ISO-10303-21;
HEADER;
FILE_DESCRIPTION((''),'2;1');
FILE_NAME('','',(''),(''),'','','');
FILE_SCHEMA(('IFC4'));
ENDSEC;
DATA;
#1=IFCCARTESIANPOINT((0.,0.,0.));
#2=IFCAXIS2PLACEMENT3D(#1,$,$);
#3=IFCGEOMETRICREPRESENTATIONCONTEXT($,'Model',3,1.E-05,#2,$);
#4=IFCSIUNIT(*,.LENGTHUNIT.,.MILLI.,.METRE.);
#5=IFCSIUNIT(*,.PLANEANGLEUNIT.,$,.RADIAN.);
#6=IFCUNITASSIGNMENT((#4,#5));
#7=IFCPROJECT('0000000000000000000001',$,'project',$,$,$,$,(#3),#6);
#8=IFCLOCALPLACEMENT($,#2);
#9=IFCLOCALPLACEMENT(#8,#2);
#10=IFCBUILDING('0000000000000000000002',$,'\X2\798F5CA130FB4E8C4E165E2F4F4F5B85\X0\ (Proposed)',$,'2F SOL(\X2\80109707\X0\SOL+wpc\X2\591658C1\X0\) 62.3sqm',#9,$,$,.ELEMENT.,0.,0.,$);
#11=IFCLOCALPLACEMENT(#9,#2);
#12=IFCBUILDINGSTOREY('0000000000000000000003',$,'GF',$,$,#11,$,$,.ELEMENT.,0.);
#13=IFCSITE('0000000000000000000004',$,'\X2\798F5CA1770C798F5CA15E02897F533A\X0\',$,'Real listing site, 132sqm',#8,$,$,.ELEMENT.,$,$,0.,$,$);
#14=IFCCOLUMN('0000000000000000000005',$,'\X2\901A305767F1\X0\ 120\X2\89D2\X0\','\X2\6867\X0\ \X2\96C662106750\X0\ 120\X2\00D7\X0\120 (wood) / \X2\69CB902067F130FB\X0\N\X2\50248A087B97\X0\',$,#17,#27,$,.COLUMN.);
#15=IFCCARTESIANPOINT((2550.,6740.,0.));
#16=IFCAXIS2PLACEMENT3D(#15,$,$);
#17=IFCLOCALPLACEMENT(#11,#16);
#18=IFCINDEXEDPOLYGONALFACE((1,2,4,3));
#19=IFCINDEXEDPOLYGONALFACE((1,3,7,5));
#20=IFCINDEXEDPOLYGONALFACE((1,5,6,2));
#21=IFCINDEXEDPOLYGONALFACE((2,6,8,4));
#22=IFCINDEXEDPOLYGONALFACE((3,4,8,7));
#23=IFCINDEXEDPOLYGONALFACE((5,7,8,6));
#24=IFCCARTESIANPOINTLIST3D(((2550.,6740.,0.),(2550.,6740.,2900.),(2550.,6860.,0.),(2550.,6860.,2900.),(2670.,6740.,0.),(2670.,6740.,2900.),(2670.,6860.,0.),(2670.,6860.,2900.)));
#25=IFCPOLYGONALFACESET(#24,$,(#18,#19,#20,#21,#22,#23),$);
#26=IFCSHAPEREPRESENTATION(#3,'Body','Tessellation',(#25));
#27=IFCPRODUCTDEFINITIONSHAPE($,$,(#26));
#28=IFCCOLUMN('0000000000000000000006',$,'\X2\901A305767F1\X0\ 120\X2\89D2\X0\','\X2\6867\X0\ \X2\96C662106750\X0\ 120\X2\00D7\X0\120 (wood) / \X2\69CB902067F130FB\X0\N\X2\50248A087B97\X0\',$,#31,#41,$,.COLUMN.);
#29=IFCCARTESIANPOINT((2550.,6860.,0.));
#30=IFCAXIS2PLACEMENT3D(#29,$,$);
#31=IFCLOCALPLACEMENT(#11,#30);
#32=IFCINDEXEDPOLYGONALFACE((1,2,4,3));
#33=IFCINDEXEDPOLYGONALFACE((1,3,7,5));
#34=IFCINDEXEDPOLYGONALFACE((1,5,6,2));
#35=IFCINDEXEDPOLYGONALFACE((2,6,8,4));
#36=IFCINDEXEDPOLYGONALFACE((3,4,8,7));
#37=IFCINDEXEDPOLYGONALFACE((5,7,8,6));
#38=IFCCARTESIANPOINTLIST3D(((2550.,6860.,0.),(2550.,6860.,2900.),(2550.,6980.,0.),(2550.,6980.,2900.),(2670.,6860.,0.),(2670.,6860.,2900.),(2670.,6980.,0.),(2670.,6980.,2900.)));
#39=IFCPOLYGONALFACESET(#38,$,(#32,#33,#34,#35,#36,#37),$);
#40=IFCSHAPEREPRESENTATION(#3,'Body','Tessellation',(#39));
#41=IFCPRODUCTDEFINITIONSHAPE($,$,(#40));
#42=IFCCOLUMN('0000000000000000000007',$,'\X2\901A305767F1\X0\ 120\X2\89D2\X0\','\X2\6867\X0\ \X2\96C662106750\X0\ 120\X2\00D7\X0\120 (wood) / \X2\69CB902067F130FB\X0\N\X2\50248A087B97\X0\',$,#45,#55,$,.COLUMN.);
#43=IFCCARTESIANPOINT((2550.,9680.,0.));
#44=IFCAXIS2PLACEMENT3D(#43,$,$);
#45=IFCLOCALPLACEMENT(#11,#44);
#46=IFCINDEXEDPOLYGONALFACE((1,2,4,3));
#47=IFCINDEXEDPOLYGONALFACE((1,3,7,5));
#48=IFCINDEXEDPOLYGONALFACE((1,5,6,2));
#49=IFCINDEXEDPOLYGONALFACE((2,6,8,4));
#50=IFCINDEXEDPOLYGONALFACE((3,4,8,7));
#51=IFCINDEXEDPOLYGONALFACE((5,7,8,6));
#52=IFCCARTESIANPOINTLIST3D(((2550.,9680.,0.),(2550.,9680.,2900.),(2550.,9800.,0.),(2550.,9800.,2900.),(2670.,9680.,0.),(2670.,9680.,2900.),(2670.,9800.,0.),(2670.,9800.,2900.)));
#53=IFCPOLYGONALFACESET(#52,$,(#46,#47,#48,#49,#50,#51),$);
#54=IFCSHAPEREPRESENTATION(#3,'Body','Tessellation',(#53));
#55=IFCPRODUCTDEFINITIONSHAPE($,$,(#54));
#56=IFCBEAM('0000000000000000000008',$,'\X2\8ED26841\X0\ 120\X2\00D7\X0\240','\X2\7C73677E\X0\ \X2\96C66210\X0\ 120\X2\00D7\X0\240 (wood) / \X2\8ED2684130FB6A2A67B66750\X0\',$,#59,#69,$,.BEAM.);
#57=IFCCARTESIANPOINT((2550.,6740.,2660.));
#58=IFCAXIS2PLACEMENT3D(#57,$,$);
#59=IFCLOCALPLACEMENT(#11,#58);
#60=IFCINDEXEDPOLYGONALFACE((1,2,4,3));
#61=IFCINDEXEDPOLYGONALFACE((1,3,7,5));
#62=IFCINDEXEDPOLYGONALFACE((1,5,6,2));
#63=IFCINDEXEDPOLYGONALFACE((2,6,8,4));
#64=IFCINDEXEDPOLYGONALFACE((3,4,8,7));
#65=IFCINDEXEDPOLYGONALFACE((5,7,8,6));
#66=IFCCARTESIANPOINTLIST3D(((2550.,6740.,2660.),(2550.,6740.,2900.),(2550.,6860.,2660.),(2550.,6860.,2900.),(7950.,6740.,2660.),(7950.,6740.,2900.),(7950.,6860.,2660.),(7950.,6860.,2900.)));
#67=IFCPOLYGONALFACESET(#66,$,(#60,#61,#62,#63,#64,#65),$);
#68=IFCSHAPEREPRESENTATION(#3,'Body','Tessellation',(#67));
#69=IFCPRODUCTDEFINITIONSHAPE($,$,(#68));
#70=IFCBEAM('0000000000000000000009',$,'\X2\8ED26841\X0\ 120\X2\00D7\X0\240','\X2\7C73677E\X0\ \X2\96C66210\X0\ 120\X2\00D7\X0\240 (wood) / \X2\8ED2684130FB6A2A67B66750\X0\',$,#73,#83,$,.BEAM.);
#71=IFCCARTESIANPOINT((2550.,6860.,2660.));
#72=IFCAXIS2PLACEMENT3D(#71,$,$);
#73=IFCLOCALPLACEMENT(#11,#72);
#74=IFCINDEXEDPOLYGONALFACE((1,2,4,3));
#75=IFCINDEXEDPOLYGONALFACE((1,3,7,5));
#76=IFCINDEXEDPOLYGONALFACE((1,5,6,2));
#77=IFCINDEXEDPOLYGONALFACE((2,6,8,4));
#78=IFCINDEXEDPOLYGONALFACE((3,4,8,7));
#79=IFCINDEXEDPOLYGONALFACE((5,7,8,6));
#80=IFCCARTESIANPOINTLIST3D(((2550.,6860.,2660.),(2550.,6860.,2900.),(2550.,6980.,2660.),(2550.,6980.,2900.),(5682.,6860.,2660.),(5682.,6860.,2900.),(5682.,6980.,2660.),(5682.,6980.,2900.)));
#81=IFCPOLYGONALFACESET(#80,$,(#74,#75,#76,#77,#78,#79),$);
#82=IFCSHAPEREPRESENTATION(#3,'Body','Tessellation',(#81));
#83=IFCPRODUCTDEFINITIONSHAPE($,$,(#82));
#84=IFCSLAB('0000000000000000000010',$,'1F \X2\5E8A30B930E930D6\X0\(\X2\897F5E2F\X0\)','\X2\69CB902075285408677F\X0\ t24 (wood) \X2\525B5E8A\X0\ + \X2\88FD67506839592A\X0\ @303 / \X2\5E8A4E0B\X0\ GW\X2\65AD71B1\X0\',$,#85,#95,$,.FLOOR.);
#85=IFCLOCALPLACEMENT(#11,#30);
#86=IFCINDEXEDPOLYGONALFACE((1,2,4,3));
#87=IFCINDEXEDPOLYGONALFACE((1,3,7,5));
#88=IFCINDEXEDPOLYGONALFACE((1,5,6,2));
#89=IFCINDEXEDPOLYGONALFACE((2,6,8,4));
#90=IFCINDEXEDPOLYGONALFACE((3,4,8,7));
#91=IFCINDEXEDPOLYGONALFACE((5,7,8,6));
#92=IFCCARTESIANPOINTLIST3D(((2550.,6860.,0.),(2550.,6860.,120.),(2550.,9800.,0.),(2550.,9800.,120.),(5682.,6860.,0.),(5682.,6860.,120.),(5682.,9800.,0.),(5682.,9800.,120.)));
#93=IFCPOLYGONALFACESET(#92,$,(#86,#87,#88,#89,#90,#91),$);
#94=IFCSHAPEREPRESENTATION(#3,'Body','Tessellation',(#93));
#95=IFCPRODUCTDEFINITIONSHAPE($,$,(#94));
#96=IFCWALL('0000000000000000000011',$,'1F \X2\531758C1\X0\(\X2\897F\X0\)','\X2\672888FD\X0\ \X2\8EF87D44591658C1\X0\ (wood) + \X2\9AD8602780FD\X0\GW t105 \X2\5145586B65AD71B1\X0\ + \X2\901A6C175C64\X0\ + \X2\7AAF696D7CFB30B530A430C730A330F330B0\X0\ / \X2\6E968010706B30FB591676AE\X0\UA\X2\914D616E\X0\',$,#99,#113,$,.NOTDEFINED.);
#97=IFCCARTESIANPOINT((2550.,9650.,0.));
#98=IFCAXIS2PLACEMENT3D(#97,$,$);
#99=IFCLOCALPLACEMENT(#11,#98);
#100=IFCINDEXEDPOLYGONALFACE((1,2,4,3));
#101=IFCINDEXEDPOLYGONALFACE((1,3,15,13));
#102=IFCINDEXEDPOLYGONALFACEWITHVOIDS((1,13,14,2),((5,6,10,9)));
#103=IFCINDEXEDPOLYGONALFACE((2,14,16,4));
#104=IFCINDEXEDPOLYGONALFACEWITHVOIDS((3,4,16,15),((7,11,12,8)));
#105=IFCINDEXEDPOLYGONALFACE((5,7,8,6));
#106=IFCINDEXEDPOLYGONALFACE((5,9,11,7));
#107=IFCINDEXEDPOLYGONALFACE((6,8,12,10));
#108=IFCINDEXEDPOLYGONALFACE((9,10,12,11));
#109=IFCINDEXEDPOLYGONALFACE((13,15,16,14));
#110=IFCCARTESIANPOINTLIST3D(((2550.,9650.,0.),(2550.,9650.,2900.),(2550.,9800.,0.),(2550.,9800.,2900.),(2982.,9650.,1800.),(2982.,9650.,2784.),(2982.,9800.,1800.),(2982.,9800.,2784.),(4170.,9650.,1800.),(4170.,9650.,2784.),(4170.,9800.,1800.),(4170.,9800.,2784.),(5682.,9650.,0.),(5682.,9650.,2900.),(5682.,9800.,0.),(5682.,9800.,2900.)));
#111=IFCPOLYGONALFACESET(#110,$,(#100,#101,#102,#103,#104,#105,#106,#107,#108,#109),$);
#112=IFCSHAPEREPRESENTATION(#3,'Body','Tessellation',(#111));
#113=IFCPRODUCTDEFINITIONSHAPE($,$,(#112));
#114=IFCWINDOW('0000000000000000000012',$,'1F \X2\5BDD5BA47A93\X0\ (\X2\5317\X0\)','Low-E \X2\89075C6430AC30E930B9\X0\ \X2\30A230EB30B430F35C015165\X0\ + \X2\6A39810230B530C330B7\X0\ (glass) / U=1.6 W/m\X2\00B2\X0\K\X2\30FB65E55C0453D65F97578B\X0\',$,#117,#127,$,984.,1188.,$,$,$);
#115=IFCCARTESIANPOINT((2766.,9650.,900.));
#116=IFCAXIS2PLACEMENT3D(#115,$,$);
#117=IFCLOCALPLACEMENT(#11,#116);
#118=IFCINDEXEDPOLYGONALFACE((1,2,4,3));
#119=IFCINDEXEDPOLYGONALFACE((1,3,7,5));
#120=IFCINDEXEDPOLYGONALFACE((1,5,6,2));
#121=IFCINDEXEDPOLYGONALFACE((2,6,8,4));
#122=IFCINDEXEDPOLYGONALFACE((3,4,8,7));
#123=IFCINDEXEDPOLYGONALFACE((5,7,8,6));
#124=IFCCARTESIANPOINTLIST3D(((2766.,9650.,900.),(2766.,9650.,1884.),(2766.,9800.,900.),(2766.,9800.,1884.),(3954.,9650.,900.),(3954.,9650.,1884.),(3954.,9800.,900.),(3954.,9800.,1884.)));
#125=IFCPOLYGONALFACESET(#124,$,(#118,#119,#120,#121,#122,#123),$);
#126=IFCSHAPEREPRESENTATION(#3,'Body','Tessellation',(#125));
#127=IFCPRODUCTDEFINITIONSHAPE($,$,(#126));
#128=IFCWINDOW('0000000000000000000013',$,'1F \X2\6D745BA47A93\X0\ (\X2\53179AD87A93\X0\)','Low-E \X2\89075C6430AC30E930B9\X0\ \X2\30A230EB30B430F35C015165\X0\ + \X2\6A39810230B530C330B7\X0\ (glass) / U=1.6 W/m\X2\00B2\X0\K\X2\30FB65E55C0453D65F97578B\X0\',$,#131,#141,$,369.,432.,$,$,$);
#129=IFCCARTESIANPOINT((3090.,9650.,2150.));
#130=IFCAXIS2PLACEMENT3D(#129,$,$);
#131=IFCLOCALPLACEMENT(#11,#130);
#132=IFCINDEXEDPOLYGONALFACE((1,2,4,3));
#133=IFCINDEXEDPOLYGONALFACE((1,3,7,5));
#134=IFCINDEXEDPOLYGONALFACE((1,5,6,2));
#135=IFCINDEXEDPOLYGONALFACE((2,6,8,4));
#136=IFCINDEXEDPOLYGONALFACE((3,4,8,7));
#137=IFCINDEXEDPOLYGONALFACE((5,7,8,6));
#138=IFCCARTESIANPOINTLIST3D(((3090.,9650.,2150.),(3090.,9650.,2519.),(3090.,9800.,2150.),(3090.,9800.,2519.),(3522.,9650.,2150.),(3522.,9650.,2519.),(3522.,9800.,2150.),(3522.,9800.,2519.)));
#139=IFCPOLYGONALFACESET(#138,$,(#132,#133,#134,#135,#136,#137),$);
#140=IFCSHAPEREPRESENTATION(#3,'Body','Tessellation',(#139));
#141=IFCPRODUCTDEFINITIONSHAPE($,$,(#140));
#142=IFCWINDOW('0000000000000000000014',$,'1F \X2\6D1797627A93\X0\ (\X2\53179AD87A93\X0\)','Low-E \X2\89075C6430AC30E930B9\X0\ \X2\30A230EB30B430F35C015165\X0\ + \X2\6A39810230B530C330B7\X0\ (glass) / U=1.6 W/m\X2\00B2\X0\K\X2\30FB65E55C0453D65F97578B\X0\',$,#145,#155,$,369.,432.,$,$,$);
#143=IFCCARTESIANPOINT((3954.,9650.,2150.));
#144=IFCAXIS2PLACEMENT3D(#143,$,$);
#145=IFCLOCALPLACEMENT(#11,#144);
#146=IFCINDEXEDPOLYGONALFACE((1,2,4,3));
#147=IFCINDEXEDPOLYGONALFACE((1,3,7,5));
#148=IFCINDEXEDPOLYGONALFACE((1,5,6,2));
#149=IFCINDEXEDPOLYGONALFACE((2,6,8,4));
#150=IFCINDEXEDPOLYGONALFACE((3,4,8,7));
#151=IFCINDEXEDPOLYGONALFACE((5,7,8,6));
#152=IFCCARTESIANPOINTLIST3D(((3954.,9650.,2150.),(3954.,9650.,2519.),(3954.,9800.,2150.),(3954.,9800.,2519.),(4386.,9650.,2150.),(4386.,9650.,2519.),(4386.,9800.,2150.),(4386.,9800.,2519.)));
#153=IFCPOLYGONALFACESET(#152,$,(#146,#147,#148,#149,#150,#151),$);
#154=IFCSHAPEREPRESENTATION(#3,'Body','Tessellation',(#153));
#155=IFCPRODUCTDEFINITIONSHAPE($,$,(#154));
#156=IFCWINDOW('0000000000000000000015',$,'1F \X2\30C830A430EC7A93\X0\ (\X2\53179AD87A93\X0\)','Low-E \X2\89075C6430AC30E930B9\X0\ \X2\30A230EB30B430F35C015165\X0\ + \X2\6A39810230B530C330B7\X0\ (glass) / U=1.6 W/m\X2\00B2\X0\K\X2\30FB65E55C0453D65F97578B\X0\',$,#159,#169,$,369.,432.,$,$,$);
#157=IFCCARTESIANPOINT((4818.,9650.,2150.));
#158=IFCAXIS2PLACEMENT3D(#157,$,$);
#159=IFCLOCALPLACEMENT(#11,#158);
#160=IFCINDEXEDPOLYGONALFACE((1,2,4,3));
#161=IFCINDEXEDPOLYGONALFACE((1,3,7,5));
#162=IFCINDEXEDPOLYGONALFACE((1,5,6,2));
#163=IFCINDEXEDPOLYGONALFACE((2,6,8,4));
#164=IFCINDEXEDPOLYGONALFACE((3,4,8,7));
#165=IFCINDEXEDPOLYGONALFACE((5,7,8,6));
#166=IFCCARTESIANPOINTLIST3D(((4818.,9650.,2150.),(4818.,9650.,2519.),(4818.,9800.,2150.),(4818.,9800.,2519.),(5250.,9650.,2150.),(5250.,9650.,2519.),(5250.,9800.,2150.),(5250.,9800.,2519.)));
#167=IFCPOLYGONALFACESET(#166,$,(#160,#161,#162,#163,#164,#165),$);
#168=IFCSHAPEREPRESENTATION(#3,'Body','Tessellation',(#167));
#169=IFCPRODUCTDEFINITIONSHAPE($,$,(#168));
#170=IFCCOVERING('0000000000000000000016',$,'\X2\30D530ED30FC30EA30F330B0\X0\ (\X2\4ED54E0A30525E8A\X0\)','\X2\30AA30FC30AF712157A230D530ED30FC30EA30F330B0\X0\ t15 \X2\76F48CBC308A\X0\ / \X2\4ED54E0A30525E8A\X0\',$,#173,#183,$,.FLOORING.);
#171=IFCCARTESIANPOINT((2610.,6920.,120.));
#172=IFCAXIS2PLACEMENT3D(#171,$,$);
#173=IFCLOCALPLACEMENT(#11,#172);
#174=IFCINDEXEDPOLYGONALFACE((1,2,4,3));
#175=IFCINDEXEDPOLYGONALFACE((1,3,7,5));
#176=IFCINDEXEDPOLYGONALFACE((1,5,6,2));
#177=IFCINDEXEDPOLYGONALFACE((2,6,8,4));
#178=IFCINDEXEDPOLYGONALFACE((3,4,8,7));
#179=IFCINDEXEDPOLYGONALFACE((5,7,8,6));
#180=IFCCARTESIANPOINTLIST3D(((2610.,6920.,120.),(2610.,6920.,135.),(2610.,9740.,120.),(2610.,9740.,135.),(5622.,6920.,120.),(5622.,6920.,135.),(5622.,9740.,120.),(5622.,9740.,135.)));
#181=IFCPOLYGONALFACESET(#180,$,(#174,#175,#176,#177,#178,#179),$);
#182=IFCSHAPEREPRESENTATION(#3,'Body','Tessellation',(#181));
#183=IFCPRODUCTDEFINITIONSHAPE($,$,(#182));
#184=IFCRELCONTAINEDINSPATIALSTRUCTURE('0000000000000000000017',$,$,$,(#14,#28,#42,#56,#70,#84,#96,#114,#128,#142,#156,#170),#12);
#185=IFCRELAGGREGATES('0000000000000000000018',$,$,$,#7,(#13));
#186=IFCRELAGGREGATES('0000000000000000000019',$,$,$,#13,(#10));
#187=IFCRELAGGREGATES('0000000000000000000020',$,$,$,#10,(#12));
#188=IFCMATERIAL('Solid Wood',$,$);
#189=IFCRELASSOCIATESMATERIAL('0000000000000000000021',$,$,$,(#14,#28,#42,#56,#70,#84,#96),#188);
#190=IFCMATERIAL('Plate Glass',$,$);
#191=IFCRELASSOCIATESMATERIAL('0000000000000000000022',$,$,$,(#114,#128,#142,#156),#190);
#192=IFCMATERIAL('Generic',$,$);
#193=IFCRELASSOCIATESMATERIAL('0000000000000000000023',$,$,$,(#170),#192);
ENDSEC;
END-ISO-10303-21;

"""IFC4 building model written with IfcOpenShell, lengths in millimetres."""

from ifc_helpers import new_model, si_unit, frame, frame_2d, origin, place, context, project, spatial, rectangle, extrude, material, element, fill, save


model = new_model("IFC4")

# Units and contexts
model_context = context("Model", 3, precision=1e-05, world=origin())
ifc_project = project(units=[si_unit("LENGTHUNIT", "METRE", prefix="MILLI"), si_unit("PLANEANGLEUNIT", "RADIAN")], contexts=[model_context])

# Site, building, storey
site_placement = place(None, origin())
site = spatial("IfcSite", under=ifc_project, at=site_placement, Name="福岡県福岡市西区", ObjectType="Real listing site, 132sqm", CompositionType="ELEMENT", RefElevation=0.0)
building_placement = place(site_placement, origin())
building = spatial("IfcBuilding", under=site, at=building_placement, Name="福岡・二世帯住宅 (Proposed)", ObjectType="2F SOL(耐震SOL+wpc外壁) 62.3sqm", CompositionType="ELEMENT", ElevationOfRefHeight=0.0, ElevationOfTerrain=0.0)
storey_placement = place(building_placement, origin())
storey = spatial("IfcBuildingStorey", under=building, at=storey_placement, Name="GF", CompositionType="ELEMENT", Elevation=0.0)

# Columns
ifc_material_1 = material(Name="Solid Wood")
column_1_placement = place(storey_placement, frame((2550.0, 6740.0, 0.0)))
element("IfcColumn", 1, at=column_1_placement, inside=storey, material=ifc_material_1, Name="通し柱 120角", Description="桧 集成材 120×120 (wood) / 構造柱・N値計算", PredefinedType="COLUMN", context=model_context, shape_type="SweptSolid", body=[
    extrude(rectangle(XDim=120.0, YDim=120.0, at=frame_2d((60.0, 60.0))), frame((2550.0, 6740.0, 0.0)), (0.0, 0.0, 1.0), 2900.0),
])
column_2_placement = place(storey_placement, frame((2550.0, 6860.0, 0.0)))
element("IfcColumn", 2, at=column_2_placement, inside=storey, material=ifc_material_1, Name="通し柱 120角", Description="桧 集成材 120×120 (wood) / 構造柱・N値計算", PredefinedType="COLUMN", context=model_context, shape_type="SweptSolid", body=[
    extrude(rectangle(XDim=120.0, YDim=120.0, at=frame_2d((60.0, 60.0))), frame((2550.0, 6860.0, 0.0)), (0.0, 0.0, 1.0), 2900.0),
])
column_3_placement = place(storey_placement, frame((2550.0, 9680.0, 0.0)))
element("IfcColumn", 3, at=column_3_placement, inside=storey, material=ifc_material_1, Name="通し柱 120角", Description="桧 集成材 120×120 (wood) / 構造柱・N値計算", PredefinedType="COLUMN", context=model_context, shape_type="SweptSolid", body=[
    extrude(rectangle(XDim=120.0, YDim=120.0, at=frame_2d((60.0, 60.0))), frame((2550.0, 9680.0, 0.0)), (0.0, 0.0, 1.0), 2900.0),
])

# Beams
beam_1_placement = place(storey_placement, frame((2550.0, 6740.0, 2660.0)))
element("IfcBeam", 4, at=beam_1_placement, inside=storey, material=ifc_material_1, Name="軒桁 120×240", Description="米松 集成 120×240 (wood) / 軒桁・横架材", PredefinedType="BEAM", context=model_context, shape_type="SweptSolid", body=[
    extrude(rectangle(XDim=5400.0, YDim=120.0, at=frame_2d((2700.0, 60.0))), frame((2550.0, 6740.0, 2660.0)), (0.0, 0.0, 1.0), 240.0),
])
beam_2_placement = place(storey_placement, frame((2550.0, 6860.0, 2660.0)))
element("IfcBeam", 5, at=beam_2_placement, inside=storey, material=ifc_material_1, Name="軒桁 120×240", Description="米松 集成 120×240 (wood) / 軒桁・横架材", PredefinedType="BEAM", context=model_context, shape_type="SweptSolid", body=[
    extrude(rectangle(XDim=3132.0, YDim=120.0, at=frame_2d((1566.0, 60.0))), frame((2550.0, 6860.0, 2660.0)), (0.0, 0.0, 1.0), 240.0),
])

# Slab
slab_placement = place(storey_placement, frame((2550.0, 6860.0, 0.0)))
element("IfcSlab", 6, at=slab_placement, inside=storey, material=ifc_material_1, Name="1F 床スラブ(西帯)", Description="構造用合板 t24 (wood) 剛床 + 製材根太 @303 / 床下 GW断熱", PredefinedType="FLOOR", context=model_context, shape_type="SweptSolid", body=[
    extrude(rectangle(XDim=3132.0, YDim=2940.0, at=frame_2d((1566.0, 1470.0))), frame((2550.0, 6860.0, 0.0)), (0.0, 0.0, 1.0), 120.0),
])

# Wall, openings, windows
wall_1_placement = place(storey_placement, frame((2550.0, 9650.0, 0.0)))
wall_1 = element("IfcWall", 7, at=wall_1_placement, inside=storey, material=ifc_material_1, Name="1F 北壁(西)", Description="木製 軸組外壁 (wood) + 高性能GW t105 充填断熱 + 通気層 + 窯業系サイディング / 準耐火・外皮UA配慮", PredefinedType="NOTDEFINED", context=model_context, shape_type="SweptSolid", body=[
    extrude(rectangle(XDim=3132.0, YDim=150.0, at=frame_2d((1566.0, 75.0))), frame((2550.0, 9650.0, 0.0)), (0.0, 0.0, 1.0), 2900.0),
])
opening_1_placement = place(storey_placement, frame((2766.0, 9650.0, 900.0)))
opening_1 = element("IfcOpeningElement", 8, at=opening_1_placement, cuts=wall_1, PredefinedType="NOTDEFINED", context=model_context, shape_type="SweptSolid", body=[
    extrude(rectangle(XDim=1188.0, YDim=150.0, at=frame_2d((594.0, 75.0))), frame((2766.0, 9650.0, 900.0)), (0.0, 0.0, 1.0), 984.0),
])
opening_2_placement = place(storey_placement, frame((3090.0, 9650.0, 2150.0)))
opening_2 = element("IfcOpeningElement", 9, at=opening_2_placement, cuts=wall_1, PredefinedType="NOTDEFINED", context=model_context, shape_type="SweptSolid", body=[
    extrude(rectangle(XDim=432.0, YDim=150.0, at=frame_2d((216.0, 75.0))), frame((3090.0, 9650.0, 2150.0)), (0.0, 0.0, 1.0), 369.0),
])
opening_3_placement = place(storey_placement, frame((3954.0, 9650.0, 2150.0)))
opening_3 = element("IfcOpeningElement", 10, at=opening_3_placement, cuts=wall_1, PredefinedType="NOTDEFINED", context=model_context, shape_type="SweptSolid", body=[
    extrude(rectangle(XDim=432.0, YDim=150.0, at=frame_2d((216.0, 75.0))), frame((3954.0, 9650.0, 2150.0)), (0.0, 0.0, 1.0), 369.0),
])
opening_4_placement = place(storey_placement, frame((4818.0, 9650.0, 2150.0)))
opening_4 = element("IfcOpeningElement", 11, at=opening_4_placement, cuts=wall_1, PredefinedType="NOTDEFINED", context=model_context, shape_type="SweptSolid", body=[
    extrude(rectangle(XDim=432.0, YDim=150.0, at=frame_2d((216.0, 75.0))), frame((4818.0, 9650.0, 2150.0)), (0.0, 0.0, 1.0), 369.0),
])
ifc_material_2 = material(Name="Plate Glass")
window_1_placement = place(storey_placement, frame((2766.0, 9650.0, 900.0)))
window_1 = element("IfcWindow", 12, at=window_1_placement, inside=storey, material=ifc_material_2, Name="1F 寝室窓 (北)", Description="Low-E 複層ガラス アルゴン封入 + 樹脂サッシ (glass) / U=1.6 W/m²K・日射取得型", OverallHeight=984.0, OverallWidth=1188.0, context=model_context, shape_type="SweptSolid", body=[
    extrude(rectangle(XDim=1188.0, YDim=150.0, at=frame_2d((594.0, 75.0))), frame((2766.0, 9650.0, 900.0)), (0.0, 0.0, 1.0), 984.0),
])
fill(opening_1, window_1)
window_2_placement = place(storey_placement, frame((3090.0, 9650.0, 2150.0)))
window_2 = element("IfcWindow", 13, at=window_2_placement, inside=storey, material=ifc_material_2, Name="1F 浴室窓 (北高窓)", Description="Low-E 複層ガラス アルゴン封入 + 樹脂サッシ (glass) / U=1.6 W/m²K・日射取得型", OverallHeight=369.0, OverallWidth=432.0, context=model_context, shape_type="SweptSolid", body=[
    extrude(rectangle(XDim=432.0, YDim=150.0, at=frame_2d((216.0, 75.0))), frame((3090.0, 9650.0, 2150.0)), (0.0, 0.0, 1.0), 369.0),
])
fill(opening_2, window_2)
window_3_placement = place(storey_placement, frame((3954.0, 9650.0, 2150.0)))
window_3 = element("IfcWindow", 14, at=window_3_placement, inside=storey, material=ifc_material_2, Name="1F 洗面窓 (北高窓)", Description="Low-E 複層ガラス アルゴン封入 + 樹脂サッシ (glass) / U=1.6 W/m²K・日射取得型", OverallHeight=369.0, OverallWidth=432.0, context=model_context, shape_type="SweptSolid", body=[
    extrude(rectangle(XDim=432.0, YDim=150.0, at=frame_2d((216.0, 75.0))), frame((3954.0, 9650.0, 2150.0)), (0.0, 0.0, 1.0), 369.0),
])
fill(opening_3, window_3)
window_4_placement = place(storey_placement, frame((4818.0, 9650.0, 2150.0)))
window_4 = element("IfcWindow", 15, at=window_4_placement, inside=storey, material=ifc_material_2, Name="1F トイレ窓 (北高窓)", Description="Low-E 複層ガラス アルゴン封入 + 樹脂サッシ (glass) / U=1.6 W/m²K・日射取得型", OverallHeight=369.0, OverallWidth=432.0, context=model_context, shape_type="SweptSolid", body=[
    extrude(rectangle(XDim=432.0, YDim=150.0, at=frame_2d((216.0, 75.0))), frame((4818.0, 9650.0, 2150.0)), (0.0, 0.0, 1.0), 369.0),
])
fill(opening_4, window_4)

# Covering
ifc_material_3 = material(Name="Generic")
covering_placement = place(storey_placement, frame((2610.0, 6920.0, 120.0)))
element("IfcCovering", 16, at=covering_placement, inside=storey, material=ifc_material_3, Name="フローリング (仕上げ床)", Description="オーク無垢フローリング t15 直貼り / 仕上げ床", PredefinedType="FLOORING", context=model_context, shape_type="SweptSolid", body=[
    extrude(rectangle(XDim=3012.0, YDim=2820.0, at=frame_2d((1506.0, 1410.0))), frame((2610.0, 6920.0, 120.0)), (0.0, 0.0, 1.0), 15.0),
])

save(model, "model.ifc")
